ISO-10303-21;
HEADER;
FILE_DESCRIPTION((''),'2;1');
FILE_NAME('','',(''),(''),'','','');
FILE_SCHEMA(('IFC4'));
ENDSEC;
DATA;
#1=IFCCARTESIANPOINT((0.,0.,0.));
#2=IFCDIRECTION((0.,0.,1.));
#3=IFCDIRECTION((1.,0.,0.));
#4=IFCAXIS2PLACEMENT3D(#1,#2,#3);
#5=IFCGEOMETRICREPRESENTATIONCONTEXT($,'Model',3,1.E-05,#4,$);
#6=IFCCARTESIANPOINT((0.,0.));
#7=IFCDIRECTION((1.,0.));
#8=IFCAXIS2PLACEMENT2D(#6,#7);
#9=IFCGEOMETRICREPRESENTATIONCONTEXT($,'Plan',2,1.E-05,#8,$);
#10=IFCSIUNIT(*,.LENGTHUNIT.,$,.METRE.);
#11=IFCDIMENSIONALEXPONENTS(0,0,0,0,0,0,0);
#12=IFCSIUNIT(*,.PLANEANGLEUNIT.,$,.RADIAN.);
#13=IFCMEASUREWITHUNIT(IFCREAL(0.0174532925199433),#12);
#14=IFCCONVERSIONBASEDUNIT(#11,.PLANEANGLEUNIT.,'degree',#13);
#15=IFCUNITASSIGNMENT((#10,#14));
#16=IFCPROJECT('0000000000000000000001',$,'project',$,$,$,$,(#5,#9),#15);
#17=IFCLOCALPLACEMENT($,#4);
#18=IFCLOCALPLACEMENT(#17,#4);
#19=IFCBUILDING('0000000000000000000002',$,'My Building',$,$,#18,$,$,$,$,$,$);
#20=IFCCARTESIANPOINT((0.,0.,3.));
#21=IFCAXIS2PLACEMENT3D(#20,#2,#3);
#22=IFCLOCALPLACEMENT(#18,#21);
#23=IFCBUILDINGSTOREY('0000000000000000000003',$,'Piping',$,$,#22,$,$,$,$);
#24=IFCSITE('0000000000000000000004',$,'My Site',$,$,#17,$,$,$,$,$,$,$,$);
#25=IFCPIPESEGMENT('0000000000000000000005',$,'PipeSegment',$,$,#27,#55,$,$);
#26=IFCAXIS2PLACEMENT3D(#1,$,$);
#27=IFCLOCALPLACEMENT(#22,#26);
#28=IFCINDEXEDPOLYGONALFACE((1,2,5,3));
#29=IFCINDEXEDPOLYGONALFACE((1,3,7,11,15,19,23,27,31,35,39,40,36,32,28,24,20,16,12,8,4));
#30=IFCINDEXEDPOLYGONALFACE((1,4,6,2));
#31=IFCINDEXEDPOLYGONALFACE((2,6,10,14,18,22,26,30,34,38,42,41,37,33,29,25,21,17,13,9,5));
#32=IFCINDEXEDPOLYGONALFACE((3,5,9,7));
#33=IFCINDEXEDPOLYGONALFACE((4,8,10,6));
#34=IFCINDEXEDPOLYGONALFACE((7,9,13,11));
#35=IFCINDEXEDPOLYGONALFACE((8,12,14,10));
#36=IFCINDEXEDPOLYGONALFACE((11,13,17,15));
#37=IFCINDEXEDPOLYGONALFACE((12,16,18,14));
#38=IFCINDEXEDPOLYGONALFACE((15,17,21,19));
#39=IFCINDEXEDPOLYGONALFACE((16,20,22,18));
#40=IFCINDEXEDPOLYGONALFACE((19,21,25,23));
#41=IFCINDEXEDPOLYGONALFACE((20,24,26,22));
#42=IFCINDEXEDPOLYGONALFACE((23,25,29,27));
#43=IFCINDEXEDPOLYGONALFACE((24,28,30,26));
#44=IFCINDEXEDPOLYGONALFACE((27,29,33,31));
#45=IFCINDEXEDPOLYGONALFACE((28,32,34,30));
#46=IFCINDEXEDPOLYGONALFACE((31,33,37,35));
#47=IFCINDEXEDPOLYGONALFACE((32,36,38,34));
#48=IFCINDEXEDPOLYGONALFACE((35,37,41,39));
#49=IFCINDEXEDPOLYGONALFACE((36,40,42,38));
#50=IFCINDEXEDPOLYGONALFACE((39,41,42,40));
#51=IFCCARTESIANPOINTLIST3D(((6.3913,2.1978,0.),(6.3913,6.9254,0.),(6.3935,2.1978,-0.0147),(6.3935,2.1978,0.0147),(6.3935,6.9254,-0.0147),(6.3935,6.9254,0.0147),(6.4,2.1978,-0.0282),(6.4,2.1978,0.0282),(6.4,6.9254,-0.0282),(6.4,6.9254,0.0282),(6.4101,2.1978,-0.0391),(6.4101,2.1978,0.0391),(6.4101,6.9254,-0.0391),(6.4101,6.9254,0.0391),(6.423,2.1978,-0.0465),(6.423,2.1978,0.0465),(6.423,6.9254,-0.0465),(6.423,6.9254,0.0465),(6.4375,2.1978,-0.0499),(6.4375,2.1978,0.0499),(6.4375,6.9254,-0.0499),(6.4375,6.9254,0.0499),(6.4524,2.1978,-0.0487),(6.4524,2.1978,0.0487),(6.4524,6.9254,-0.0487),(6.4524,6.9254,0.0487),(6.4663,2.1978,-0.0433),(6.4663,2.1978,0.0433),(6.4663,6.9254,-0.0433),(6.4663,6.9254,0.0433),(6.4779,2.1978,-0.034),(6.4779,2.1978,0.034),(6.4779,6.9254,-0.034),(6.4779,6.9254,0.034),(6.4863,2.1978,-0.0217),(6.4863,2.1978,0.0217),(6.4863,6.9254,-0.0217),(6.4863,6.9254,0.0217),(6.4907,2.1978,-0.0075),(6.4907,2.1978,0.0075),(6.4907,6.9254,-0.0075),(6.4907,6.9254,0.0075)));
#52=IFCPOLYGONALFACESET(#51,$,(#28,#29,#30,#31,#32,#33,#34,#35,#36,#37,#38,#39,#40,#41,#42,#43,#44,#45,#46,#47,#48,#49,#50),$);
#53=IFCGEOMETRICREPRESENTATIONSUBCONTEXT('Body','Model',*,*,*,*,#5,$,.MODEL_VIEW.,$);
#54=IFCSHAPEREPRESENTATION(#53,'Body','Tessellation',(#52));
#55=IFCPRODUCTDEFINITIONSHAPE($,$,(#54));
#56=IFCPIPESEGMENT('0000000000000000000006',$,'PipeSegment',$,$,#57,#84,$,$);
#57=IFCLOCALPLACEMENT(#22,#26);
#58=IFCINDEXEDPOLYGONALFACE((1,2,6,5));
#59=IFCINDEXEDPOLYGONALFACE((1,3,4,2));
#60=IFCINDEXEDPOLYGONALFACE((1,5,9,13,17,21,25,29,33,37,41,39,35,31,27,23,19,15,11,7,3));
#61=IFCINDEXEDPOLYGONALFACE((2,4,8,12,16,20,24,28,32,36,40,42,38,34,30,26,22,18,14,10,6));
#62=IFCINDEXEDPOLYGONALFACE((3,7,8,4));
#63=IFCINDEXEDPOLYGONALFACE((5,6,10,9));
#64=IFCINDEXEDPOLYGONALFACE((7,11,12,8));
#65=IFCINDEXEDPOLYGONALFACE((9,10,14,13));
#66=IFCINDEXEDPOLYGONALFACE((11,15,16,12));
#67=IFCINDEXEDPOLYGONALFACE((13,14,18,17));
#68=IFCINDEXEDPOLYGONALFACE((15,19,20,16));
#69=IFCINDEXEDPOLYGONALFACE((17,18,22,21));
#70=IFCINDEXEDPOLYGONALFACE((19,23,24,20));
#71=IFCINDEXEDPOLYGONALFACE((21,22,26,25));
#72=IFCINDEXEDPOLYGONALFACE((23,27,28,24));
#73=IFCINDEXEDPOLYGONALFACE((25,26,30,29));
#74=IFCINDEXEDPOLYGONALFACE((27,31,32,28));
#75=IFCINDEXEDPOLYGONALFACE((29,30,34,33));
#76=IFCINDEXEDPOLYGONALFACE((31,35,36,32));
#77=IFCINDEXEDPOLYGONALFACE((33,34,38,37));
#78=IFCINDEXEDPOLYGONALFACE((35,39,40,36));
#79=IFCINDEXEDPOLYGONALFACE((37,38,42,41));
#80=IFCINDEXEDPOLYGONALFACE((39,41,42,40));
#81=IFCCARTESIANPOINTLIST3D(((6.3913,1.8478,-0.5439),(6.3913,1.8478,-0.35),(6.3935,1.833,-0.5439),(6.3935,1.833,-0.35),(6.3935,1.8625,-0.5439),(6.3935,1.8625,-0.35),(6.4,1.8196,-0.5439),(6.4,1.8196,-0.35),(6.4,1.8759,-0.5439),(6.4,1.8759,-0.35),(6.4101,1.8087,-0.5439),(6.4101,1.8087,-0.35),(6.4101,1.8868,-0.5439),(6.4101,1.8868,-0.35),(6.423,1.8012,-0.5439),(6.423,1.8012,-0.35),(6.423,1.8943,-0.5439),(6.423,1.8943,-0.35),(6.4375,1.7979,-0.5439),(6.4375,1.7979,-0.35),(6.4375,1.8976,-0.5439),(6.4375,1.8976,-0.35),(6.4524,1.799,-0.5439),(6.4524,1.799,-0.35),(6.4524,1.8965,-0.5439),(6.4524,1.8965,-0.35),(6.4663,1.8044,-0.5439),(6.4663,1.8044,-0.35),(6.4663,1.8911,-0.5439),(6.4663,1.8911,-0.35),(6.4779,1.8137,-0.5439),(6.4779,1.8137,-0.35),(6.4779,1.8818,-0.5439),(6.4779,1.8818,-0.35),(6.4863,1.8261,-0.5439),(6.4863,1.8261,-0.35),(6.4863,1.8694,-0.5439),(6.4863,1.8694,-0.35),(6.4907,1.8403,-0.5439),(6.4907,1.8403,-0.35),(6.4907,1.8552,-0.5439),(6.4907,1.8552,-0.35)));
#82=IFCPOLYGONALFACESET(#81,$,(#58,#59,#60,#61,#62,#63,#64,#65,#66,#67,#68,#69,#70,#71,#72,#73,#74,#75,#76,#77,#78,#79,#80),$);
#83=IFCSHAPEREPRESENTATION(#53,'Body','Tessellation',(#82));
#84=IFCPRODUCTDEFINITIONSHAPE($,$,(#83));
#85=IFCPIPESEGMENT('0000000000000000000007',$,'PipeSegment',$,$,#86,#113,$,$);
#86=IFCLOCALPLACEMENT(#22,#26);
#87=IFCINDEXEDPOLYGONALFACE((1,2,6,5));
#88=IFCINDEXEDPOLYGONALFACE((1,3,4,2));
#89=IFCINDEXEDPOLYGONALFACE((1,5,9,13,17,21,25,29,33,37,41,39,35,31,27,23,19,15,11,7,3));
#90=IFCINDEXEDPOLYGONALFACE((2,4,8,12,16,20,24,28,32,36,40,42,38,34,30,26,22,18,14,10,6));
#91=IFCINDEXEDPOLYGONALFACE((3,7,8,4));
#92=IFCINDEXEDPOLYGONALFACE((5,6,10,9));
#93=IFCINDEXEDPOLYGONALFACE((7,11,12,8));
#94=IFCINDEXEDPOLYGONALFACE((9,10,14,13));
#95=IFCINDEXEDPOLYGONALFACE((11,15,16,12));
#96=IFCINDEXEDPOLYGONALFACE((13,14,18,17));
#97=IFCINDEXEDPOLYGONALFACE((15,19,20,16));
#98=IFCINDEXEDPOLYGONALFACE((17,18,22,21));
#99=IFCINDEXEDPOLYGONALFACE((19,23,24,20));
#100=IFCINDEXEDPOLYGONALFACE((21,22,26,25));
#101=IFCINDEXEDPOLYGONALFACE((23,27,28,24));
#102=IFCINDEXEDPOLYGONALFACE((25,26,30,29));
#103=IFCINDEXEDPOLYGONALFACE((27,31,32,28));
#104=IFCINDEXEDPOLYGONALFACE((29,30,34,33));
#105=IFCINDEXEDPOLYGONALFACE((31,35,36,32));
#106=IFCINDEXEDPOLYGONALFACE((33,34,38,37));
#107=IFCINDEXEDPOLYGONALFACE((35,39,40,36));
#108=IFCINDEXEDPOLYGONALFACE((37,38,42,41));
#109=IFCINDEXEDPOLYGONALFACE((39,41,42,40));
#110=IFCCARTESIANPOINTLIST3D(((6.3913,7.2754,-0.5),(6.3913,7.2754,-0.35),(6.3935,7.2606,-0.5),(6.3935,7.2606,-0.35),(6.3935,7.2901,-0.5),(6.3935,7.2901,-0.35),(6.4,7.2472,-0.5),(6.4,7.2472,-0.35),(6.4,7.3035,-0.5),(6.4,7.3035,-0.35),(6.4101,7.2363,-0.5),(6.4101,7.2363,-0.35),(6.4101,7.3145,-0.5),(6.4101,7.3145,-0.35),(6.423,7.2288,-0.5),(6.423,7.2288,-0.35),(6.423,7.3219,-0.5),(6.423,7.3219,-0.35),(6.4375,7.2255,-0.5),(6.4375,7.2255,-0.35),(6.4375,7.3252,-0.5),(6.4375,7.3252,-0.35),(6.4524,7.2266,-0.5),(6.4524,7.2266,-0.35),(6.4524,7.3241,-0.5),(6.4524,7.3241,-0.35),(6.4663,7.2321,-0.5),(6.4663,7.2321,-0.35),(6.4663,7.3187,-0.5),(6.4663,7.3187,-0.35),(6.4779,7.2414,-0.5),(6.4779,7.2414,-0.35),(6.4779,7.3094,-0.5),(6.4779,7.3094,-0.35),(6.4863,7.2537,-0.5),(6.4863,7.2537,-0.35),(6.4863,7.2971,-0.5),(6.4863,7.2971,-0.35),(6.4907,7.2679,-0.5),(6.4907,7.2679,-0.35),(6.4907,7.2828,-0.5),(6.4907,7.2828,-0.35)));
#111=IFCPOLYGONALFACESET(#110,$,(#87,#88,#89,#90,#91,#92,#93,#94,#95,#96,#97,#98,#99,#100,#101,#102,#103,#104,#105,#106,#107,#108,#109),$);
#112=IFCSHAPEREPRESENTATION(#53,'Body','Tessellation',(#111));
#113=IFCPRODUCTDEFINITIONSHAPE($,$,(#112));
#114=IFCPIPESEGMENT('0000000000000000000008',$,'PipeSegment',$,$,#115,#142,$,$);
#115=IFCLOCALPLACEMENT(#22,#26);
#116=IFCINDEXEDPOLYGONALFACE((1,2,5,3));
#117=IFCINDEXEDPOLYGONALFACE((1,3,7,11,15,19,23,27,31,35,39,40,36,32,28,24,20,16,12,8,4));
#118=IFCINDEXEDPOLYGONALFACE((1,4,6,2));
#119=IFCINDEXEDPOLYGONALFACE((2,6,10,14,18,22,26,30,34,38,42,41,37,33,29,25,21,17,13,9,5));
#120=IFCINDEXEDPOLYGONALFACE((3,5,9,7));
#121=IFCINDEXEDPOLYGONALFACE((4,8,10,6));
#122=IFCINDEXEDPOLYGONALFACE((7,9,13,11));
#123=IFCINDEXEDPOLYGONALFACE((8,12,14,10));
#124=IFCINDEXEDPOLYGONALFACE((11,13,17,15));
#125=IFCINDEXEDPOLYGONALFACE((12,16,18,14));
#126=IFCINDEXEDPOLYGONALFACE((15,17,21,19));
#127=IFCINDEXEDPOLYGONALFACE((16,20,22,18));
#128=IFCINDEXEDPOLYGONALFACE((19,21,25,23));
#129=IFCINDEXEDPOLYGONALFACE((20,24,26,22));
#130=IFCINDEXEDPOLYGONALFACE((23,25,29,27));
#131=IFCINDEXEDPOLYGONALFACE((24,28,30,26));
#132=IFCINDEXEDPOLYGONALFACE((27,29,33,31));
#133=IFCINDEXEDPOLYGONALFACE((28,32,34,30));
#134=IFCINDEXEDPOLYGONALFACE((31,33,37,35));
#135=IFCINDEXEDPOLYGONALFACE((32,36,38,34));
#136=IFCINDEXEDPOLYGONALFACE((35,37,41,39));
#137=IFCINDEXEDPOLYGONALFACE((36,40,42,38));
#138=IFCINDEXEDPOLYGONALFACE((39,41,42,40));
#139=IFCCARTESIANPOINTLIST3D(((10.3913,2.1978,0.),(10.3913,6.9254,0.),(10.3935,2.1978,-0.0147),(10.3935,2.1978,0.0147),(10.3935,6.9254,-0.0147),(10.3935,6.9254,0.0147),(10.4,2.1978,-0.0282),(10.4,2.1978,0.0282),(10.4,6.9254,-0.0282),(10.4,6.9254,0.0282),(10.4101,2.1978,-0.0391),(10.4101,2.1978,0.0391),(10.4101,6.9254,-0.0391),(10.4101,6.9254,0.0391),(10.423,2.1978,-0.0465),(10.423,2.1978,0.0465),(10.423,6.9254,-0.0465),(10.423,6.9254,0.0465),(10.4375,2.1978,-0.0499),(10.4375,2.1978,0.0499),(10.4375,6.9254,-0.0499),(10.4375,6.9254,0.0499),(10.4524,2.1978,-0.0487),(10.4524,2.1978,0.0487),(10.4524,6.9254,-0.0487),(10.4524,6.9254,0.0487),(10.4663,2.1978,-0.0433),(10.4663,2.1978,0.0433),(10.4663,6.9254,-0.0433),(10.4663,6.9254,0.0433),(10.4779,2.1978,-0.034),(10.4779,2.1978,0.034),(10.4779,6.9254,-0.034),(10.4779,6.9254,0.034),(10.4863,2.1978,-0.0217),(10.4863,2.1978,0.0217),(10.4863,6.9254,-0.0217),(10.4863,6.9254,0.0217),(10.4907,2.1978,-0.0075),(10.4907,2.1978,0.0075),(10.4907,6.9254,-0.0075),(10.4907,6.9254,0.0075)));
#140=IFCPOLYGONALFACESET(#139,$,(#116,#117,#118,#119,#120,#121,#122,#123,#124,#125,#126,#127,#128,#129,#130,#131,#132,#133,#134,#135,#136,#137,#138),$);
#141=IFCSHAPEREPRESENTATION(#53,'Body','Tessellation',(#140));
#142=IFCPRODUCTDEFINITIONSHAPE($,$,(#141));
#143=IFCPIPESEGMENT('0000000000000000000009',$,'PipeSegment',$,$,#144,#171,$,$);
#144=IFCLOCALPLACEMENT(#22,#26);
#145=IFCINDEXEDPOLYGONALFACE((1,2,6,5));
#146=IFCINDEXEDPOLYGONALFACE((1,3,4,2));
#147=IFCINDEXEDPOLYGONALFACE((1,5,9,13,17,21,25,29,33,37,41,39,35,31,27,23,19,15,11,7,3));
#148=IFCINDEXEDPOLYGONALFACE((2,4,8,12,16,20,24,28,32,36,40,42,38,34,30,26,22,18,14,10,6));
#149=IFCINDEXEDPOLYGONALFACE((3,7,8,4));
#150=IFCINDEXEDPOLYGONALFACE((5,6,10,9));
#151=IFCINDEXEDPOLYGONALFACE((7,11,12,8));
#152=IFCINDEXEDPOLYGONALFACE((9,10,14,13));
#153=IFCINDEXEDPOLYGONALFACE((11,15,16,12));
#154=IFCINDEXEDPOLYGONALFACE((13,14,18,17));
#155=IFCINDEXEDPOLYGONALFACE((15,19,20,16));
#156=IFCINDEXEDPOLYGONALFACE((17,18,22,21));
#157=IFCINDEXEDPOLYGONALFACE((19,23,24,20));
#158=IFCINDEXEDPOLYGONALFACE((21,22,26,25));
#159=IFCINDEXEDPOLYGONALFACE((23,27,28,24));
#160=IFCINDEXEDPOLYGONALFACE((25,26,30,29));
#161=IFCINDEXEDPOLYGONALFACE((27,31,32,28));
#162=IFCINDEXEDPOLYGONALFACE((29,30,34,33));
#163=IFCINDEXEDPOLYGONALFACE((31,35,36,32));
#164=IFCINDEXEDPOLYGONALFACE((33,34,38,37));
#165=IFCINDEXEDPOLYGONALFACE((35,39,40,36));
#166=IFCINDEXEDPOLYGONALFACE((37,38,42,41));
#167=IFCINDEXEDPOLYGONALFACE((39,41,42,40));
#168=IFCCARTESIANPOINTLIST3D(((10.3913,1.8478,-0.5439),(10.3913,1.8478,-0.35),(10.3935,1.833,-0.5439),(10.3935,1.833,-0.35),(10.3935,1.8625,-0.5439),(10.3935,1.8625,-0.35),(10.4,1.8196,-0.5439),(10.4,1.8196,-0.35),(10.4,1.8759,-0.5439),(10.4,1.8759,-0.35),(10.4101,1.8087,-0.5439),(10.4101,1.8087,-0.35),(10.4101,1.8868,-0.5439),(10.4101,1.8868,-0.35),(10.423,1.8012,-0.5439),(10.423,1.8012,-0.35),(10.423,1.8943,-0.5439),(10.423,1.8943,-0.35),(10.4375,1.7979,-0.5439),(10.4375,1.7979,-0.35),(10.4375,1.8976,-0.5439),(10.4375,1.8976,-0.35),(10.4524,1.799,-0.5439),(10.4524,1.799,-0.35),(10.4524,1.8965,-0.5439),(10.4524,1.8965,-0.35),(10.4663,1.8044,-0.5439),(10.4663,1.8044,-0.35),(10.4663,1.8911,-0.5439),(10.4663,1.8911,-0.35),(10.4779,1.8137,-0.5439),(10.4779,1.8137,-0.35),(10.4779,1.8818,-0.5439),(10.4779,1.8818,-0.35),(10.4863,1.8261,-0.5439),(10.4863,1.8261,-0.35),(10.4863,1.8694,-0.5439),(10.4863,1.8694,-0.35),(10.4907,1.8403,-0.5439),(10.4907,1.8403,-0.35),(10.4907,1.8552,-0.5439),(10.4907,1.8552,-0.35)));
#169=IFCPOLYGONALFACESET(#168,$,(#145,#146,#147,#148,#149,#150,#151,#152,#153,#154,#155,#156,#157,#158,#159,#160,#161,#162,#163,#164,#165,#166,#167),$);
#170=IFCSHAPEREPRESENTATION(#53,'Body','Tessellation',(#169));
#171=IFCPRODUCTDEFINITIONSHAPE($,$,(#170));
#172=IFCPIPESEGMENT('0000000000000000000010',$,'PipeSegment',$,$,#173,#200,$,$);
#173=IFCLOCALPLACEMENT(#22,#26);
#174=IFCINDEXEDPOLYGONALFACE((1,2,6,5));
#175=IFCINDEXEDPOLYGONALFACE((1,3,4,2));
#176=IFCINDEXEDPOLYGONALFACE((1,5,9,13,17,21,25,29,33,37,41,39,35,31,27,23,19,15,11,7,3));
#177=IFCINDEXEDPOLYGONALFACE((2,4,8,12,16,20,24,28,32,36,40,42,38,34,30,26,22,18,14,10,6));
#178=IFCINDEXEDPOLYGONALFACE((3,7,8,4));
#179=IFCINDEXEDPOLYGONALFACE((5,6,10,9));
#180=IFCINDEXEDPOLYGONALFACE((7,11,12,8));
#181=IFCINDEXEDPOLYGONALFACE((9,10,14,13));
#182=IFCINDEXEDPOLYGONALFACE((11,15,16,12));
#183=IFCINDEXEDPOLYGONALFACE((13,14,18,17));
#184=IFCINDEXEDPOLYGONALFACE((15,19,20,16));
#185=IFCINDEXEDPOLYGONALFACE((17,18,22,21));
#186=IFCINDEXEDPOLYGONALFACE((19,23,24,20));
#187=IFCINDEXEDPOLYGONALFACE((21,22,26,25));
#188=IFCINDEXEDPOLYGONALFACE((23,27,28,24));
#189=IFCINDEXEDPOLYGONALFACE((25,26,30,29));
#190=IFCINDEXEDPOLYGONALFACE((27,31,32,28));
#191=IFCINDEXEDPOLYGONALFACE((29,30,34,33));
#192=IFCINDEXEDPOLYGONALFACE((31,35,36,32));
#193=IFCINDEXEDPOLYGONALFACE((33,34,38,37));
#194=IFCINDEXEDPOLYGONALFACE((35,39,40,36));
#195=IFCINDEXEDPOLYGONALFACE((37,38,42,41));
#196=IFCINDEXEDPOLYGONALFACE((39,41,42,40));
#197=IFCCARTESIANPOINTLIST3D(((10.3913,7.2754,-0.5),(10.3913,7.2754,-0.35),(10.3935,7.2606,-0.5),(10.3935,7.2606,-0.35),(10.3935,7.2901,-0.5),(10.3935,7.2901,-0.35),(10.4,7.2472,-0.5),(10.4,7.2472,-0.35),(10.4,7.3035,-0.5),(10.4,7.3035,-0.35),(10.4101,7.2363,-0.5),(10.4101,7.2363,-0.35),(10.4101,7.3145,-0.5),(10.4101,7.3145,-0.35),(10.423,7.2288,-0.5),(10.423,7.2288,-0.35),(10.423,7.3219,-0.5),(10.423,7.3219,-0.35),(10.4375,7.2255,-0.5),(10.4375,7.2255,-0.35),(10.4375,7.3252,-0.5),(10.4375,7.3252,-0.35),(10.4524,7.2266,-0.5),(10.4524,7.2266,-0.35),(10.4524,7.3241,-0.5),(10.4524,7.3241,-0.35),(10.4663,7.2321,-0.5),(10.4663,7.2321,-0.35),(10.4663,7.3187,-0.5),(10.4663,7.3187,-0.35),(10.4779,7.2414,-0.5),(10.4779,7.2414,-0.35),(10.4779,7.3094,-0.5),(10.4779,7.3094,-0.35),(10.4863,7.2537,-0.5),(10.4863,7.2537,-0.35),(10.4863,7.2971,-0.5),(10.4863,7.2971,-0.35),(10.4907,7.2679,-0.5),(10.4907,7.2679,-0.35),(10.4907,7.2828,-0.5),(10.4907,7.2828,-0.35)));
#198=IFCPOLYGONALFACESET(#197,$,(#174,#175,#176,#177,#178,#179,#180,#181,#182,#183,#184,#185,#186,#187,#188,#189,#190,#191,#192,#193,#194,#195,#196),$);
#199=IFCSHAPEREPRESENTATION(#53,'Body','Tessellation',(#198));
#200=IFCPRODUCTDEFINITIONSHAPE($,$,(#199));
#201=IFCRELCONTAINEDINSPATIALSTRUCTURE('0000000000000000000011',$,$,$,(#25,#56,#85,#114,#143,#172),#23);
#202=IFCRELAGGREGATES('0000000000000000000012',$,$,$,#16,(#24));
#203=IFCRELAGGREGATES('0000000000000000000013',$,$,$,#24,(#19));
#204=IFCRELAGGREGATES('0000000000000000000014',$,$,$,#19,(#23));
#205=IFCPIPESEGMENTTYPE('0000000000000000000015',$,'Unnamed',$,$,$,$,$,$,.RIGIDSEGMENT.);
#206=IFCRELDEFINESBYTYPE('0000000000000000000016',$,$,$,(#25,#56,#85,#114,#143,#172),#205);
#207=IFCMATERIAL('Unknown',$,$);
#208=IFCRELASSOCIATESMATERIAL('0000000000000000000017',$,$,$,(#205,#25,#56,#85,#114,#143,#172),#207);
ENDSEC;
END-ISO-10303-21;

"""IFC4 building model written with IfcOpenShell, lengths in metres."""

from ifc_helpers import new_model, entity, si_unit, converted_unit, frame, origin_with_axes, origin_2d_with_axis, place, context, subcontext, project, spatial, circle, extrude, material, material_profile, profile_set, profile_usage, type_object, element, save


model = new_model("IFC4")

# Units and contexts
model_context = context("Model", 3, precision=1e-05, world=origin_with_axes())
plan_context = context("Plan", 2, precision=1e-05, world=origin_2d_with_axis())
body_context = subcontext(model_context, "Body", "Model", "MODEL_VIEW")
ifc_project = project(units=[si_unit("LENGTHUNIT", "METRE"), converted_unit("PLANEANGLEUNIT", "degree", entity("IfcReal", 0.0174532925199433), si_unit("PLANEANGLEUNIT", "RADIAN"), dimensions=[0, 0, 0, 0, 0, 0, 0])], contexts=[model_context, plan_context])

# Site, building, storey
site_placement = place(None, origin_with_axes())
site = spatial("IfcSite", under=ifc_project, at=site_placement, Name="My Site")
building_placement = place(site_placement, origin_with_axes())
building = spatial("IfcBuilding", under=site, at=building_placement, Name="My Building")
storey_placement = place(building_placement, frame((0.0, 0.0, 3.0), z_axis=(0.0, 0.0, 1.0), x_axis=(1.0, 0.0, 0.0)))
storey = spatial("IfcBuildingStorey", under=building, at=storey_placement, Name="Piping")

# Pipe segments
ifc_material = material(Name="Unknown")
ifc_material_profile = material_profile(ifc_material, circle(Radius=0.05))
ifc_profile_set = profile_set([ifc_material_profile])
pipe_segment_type = type_object("IfcPipeSegmentType", Name="Unnamed", PredefinedType="RIGIDSEGMENT", material=ifc_profile_set)
ifc_profile_usage_1 = profile_usage(ifc_profile_set, cardinal=5)
pipe_segment_1_placement = place(storey_placement, frame((6.4413, 2.1978, 0.0), z_axis=(0.0, 1.0, 0.0), x_axis=(-1.0, 0.0, 0.0)))
element("IfcPipeSegment", 1, at=pipe_segment_1_placement, inside=storey, type_object=pipe_segment_type, material=ifc_profile_usage_1, Name="PipeSegment", context=body_context, shape_type="SweptSolid", body=[
    extrude(circle(Radius=0.05), origin_with_axes(), (0.0, 0.0, 1.0), 4.7276),
])
ifc_profile_usage_2 = profile_usage(ifc_profile_set, cardinal=5)
pipe_segment_2_placement = place(storey_placement, frame((6.4413, 1.8478, -0.35), z_axis=(0.0, 0.0, -1.0), x_axis=(-1.0, 0.0, 0.0)))
element("IfcPipeSegment", 2, at=pipe_segment_2_placement, inside=storey, type_object=pipe_segment_type, material=ifc_profile_usage_2, Name="PipeSegment", context=body_context, shape_type="SweptSolid", body=[
    extrude(circle(Radius=0.05), origin_with_axes(), (0.0, 0.0, 1.0), 0.1939),
])
ifc_profile_usage_3 = profile_usage(ifc_profile_set, cardinal=5)
pipe_segment_3_placement = place(storey_placement, frame((6.4413, 7.2754, -0.35), z_axis=(0.0, 0.0, -1.0), x_axis=(-1.0, 0.0, 0.0)))
element("IfcPipeSegment", 3, at=pipe_segment_3_placement, inside=storey, type_object=pipe_segment_type, material=ifc_profile_usage_3, Name="PipeSegment", context=body_context, shape_type="SweptSolid", body=[
    extrude(circle(Radius=0.05), origin_with_axes(), (0.0, 0.0, 1.0), 0.15),
])
ifc_profile_usage_4 = profile_usage(ifc_profile_set, cardinal=5)
pipe_segment_4_placement = place(storey_placement, frame((10.4413, 2.1978, 0.0), z_axis=(0.0, 1.0, 0.0), x_axis=(-1.0, 0.0, 0.0)))
element("IfcPipeSegment", 4, at=pipe_segment_4_placement, inside=storey, type_object=pipe_segment_type, material=ifc_profile_usage_4, Name="PipeSegment", context=body_context, shape_type="SweptSolid", body=[
    extrude(circle(Radius=0.05), origin_with_axes(), (0.0, 0.0, 1.0), 4.7276),
])
ifc_profile_usage_5 = profile_usage(ifc_profile_set, cardinal=5)
pipe_segment_5_placement = place(storey_placement, frame((10.4413, 1.8478, -0.35), z_axis=(0.0, 0.0, -1.0), x_axis=(-1.0, 0.0, 0.0)))
element("IfcPipeSegment", 5, at=pipe_segment_5_placement, inside=storey, type_object=pipe_segment_type, material=ifc_profile_usage_5, Name="PipeSegment", context=body_context, shape_type="SweptSolid", body=[
    extrude(circle(Radius=0.05), origin_with_axes(), (0.0, 0.0, 1.0), 0.1939),
])
ifc_profile_usage_6 = profile_usage(ifc_profile_set, cardinal=5)
pipe_segment_6_placement = place(storey_placement, frame((10.4413, 7.2754, -0.35), z_axis=(0.0, 0.0, -1.0), x_axis=(-1.0, 0.0, 0.0)))
element("IfcPipeSegment", 6, at=pipe_segment_6_placement, inside=storey, type_object=pipe_segment_type, material=ifc_profile_usage_6, Name="PipeSegment", context=body_context, shape_type="SweptSolid", body=[
    extrude(circle(Radius=0.05), origin_with_axes(), (0.0, 0.0, 1.0), 0.15),
])

save(model, "model.ifc")
